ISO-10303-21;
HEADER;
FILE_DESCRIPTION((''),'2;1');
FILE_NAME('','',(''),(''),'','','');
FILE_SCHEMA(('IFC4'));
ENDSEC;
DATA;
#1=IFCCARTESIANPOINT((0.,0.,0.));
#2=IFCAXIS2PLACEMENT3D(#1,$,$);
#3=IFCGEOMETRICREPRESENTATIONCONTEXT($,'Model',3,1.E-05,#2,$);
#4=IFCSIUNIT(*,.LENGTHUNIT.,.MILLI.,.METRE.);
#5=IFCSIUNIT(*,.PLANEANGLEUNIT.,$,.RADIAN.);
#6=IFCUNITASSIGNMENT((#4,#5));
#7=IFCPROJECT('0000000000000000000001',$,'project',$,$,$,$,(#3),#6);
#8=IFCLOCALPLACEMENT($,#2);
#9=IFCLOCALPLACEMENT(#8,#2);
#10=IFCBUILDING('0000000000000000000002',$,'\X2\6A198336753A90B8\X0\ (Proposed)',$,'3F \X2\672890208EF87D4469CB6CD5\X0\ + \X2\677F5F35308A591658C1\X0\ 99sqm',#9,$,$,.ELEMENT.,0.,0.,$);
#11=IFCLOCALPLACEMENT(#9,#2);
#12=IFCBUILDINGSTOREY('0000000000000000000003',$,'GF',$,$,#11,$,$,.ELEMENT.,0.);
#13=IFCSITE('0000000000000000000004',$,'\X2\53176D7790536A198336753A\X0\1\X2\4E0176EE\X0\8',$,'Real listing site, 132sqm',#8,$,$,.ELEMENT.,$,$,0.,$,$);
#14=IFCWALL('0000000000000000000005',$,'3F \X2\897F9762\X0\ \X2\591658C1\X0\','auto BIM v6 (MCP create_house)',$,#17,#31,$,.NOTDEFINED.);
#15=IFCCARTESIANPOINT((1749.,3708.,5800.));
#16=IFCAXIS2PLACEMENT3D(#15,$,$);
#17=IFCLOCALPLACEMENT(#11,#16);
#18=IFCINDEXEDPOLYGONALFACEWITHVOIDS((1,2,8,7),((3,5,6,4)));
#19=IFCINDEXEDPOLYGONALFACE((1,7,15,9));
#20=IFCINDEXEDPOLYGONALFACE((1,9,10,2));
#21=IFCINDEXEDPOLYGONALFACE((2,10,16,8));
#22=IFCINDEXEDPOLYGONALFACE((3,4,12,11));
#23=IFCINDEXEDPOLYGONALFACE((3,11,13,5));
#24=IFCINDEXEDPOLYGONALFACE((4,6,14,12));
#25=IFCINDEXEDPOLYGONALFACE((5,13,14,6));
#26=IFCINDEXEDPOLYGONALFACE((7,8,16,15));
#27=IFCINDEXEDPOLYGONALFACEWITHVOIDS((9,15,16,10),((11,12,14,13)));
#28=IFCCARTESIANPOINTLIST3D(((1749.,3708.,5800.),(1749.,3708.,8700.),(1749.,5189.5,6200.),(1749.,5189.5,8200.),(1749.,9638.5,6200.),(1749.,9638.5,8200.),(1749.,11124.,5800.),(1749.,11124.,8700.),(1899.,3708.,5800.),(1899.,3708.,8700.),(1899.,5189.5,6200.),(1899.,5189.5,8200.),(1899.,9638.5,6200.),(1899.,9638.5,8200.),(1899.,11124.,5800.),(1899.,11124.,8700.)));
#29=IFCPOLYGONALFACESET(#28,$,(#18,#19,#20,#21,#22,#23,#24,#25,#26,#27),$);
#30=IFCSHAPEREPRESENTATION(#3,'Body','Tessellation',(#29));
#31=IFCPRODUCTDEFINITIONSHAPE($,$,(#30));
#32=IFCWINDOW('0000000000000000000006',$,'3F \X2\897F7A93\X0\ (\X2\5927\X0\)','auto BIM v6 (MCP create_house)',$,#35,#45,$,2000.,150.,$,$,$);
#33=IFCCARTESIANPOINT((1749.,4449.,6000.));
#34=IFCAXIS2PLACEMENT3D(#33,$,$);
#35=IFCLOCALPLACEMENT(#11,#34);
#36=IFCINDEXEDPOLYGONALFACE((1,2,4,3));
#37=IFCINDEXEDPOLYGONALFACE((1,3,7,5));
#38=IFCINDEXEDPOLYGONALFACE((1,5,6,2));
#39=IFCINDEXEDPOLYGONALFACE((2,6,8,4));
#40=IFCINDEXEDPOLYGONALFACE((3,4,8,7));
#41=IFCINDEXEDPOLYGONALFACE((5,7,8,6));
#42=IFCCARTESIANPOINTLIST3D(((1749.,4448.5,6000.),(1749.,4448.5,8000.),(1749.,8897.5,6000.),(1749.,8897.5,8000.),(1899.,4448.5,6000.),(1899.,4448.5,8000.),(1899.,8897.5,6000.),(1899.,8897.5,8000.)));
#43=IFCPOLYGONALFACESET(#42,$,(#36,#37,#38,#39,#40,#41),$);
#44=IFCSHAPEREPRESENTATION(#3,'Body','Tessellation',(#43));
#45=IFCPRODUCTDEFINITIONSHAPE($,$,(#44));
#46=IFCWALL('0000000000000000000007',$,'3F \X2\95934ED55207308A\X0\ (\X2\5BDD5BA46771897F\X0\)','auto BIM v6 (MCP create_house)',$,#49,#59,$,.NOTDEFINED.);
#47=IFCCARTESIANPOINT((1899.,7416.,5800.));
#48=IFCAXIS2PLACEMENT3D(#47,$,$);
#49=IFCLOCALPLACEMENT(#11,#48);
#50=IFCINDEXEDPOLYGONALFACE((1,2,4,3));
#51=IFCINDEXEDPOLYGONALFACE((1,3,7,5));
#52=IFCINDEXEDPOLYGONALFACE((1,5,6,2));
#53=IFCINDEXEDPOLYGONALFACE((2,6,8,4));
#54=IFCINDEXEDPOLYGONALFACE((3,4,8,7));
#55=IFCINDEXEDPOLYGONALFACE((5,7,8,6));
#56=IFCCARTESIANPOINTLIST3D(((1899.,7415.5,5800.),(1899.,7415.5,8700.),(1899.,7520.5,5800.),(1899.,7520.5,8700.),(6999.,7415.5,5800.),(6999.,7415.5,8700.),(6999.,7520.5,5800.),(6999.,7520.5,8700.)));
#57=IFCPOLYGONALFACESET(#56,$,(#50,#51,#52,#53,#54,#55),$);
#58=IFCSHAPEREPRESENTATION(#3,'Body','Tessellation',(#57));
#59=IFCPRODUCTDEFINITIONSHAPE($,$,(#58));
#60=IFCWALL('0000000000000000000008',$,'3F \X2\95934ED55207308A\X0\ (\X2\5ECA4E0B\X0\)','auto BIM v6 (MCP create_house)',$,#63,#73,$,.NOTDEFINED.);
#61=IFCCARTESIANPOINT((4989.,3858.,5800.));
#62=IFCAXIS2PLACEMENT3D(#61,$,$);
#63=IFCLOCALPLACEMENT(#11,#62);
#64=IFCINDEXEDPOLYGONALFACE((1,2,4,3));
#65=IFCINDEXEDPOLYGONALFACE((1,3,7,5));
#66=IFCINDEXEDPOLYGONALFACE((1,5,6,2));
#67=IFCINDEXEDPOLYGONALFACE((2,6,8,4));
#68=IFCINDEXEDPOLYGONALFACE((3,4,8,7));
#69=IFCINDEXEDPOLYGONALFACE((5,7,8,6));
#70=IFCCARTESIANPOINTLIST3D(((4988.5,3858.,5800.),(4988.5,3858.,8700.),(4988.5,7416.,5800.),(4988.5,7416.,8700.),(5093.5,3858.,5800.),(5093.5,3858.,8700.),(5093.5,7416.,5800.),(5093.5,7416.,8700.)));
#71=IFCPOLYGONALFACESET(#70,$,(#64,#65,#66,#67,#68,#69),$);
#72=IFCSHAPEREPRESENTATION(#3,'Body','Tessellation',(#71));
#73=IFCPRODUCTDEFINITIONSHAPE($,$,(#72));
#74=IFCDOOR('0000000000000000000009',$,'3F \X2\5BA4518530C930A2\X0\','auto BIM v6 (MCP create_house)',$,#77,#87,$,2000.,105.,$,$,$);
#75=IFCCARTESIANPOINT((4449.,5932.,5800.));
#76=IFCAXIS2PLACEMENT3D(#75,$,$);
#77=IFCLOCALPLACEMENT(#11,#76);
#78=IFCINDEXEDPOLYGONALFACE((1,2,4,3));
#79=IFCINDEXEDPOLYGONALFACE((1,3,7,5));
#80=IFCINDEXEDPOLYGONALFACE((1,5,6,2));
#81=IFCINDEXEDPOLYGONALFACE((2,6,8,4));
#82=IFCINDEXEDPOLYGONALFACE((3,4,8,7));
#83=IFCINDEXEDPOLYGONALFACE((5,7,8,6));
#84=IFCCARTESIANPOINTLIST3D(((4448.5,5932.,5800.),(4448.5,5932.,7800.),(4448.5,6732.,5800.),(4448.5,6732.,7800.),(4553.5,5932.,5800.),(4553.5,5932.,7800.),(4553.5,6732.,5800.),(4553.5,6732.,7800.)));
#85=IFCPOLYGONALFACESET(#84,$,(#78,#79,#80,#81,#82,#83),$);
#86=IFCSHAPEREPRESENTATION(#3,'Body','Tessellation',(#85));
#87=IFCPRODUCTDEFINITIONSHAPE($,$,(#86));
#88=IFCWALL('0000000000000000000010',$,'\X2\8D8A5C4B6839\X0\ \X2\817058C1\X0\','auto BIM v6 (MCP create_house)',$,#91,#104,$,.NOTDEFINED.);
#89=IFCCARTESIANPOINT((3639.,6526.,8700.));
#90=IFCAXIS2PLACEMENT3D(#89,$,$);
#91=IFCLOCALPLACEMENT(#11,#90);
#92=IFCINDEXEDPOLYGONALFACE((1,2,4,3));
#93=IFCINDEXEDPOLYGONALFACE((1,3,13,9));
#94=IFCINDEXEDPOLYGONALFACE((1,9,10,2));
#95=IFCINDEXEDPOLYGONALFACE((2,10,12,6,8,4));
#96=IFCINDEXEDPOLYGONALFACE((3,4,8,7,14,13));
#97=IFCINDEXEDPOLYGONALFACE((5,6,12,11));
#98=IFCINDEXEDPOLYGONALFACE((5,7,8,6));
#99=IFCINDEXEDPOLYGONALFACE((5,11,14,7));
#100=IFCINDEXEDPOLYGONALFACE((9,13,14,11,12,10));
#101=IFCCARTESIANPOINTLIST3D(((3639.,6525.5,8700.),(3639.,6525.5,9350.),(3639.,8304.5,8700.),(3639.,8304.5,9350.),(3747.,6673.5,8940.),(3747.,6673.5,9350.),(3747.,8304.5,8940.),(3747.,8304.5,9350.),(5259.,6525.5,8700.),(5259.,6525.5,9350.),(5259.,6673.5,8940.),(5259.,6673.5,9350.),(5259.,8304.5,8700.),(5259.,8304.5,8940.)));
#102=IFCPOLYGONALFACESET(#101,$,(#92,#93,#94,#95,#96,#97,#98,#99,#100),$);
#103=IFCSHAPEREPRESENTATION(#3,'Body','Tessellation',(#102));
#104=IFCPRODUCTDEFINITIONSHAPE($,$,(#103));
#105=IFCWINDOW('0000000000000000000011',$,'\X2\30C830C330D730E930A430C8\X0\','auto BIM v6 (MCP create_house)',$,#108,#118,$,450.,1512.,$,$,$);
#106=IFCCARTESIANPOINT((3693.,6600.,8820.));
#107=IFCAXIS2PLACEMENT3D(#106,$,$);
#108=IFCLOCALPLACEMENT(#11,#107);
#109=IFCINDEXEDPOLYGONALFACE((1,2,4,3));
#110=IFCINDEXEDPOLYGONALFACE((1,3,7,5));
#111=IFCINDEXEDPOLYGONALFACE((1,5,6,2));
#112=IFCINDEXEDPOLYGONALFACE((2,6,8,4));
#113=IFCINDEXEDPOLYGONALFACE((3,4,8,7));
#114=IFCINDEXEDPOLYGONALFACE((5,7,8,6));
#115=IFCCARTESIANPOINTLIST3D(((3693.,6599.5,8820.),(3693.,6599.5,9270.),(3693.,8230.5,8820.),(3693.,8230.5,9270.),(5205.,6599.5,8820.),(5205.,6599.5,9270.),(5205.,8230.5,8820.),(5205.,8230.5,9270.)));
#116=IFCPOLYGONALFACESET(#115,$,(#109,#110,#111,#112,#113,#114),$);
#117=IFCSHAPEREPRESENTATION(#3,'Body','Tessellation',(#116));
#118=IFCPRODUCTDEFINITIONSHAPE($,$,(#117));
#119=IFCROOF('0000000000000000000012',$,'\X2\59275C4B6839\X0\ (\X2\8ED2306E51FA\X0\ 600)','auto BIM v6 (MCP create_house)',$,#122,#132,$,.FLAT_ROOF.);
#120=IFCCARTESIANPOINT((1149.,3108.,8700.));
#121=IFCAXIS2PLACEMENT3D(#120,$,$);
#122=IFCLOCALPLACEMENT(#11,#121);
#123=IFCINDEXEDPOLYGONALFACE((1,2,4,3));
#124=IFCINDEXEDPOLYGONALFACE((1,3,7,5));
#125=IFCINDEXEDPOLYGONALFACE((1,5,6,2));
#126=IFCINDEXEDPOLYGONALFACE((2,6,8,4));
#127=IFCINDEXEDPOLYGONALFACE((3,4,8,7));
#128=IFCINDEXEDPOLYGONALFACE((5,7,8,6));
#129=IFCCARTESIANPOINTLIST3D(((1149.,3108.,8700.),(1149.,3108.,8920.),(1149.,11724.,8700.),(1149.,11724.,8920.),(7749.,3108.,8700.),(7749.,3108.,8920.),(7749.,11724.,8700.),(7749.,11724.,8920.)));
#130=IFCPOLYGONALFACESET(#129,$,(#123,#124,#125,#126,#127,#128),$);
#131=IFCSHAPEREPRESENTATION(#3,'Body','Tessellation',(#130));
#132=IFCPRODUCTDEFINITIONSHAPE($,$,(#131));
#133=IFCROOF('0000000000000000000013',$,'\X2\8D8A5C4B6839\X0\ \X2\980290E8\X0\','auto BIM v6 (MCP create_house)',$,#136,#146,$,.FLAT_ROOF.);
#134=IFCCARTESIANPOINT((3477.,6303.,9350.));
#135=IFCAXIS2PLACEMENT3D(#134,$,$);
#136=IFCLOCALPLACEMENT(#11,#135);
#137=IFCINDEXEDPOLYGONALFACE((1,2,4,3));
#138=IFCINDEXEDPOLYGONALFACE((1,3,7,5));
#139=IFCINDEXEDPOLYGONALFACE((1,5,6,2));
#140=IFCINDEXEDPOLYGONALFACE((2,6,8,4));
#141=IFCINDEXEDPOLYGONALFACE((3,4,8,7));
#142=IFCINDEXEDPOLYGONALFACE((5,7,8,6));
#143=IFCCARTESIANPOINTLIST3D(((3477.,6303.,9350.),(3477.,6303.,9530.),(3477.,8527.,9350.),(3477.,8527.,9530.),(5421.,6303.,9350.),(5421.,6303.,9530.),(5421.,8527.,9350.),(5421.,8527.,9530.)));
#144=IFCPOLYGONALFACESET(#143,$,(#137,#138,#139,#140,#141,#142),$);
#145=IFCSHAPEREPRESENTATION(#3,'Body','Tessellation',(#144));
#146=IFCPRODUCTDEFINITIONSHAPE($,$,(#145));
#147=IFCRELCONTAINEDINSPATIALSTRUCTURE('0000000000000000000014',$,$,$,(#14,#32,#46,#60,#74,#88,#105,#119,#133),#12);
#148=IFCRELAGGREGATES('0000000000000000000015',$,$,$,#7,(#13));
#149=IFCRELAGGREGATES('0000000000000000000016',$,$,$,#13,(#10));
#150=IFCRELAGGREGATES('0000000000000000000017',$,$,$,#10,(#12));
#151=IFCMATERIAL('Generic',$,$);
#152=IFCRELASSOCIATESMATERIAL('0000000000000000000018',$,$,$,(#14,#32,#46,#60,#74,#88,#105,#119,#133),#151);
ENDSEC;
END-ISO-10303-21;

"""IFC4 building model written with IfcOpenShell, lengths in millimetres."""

from ifc_helpers import new_model, si_unit, frame, frame_2d, origin, place, context, project, spatial, rectangle, extrude, material, element, fill, save


model = new_model("IFC4")

# Units and contexts
model_context = context("Model", 3, precision=1e-05, world=origin())
ifc_project = project(units=[si_unit("LENGTHUNIT", "METRE", prefix="MILLI"), si_unit("PLANEANGLEUNIT", "RADIAN")], contexts=[model_context])

# Site, building, storey
site_placement = place(None, origin())
site = spatial("IfcSite", under=ifc_project, at=site_placement, Name="北海道標茶町1丁目8", ObjectType="Real listing site, 132sqm", CompositionType="ELEMENT", RefElevation=0.0)
building_placement = place(site_placement, origin())
building = spatial("IfcBuilding", under=site, at=building_placement, Name="標茶町邸 (Proposed)", ObjectType="3F 木造軸組構法 + 板張り外壁 99sqm", CompositionType="ELEMENT", ElevationOfRefHeight=0.0, ElevationOfTerrain=0.0)
storey_placement = place(building_placement, origin())
storey = spatial("IfcBuildingStorey", under=building, at=storey_placement, Name="GF", CompositionType="ELEMENT", Elevation=0.0)

# Shared definitions
ifc_material = material(Name="Generic")

# Wall, opening, window
wall_1_placement = place(storey_placement, frame((1749.0, 3708.0, 5800.0)))
wall_1 = element("IfcWall", 1, at=wall_1_placement, inside=storey, material=ifc_material, Name="3F 西面 外壁", Description="auto BIM v6 (MCP create_house)", PredefinedType="NOTDEFINED", context=model_context, shape_type="SweptSolid", body=[
    extrude(rectangle(XDim=150.0, YDim=7416.0, at=frame_2d((75.0, 3708.0))), frame((1749.0, 3708.0, 5800.0)), (0.0, 0.0, 1.0), 2900.0),
])
opening_1_placement = place(storey_placement, frame((1749.0, 4449.0, 6000.0)))
opening_1 = element("IfcOpeningElement", 2, at=opening_1_placement, cuts=wall_1, PredefinedType="NOTDEFINED", context=model_context, shape_type="SweptSolid", body=[
    extrude(rectangle(XDim=150.0, YDim=4449.0, at=frame_2d((75.0, 2224.0))), frame((1749.0, 4449.0, 6000.0)), (0.0, 0.0, 1.0), 2000.0),
])
window_1_placement = place(storey_placement, frame((1749.0, 4449.0, 6000.0)))
window_1 = element("IfcWindow", 3, at=window_1_placement, inside=storey, material=ifc_material, Name="3F 西窓 (大)", Description="auto BIM v6 (MCP create_house)", OverallHeight=2000.0, OverallWidth=150.0, context=model_context, shape_type="SweptSolid", body=[
    extrude(rectangle(XDim=150.0, YDim=4449.0, at=frame_2d((75.0, 2224.0))), frame((1749.0, 4449.0, 6000.0)), (0.0, 0.0, 1.0), 2000.0),
])
fill(opening_1, window_1)

# Walls
wall_2_placement = place(storey_placement, frame((1899.0, 7416.0, 5800.0)))
element("IfcWall", 4, at=wall_2_placement, inside=storey, material=ifc_material, Name="3F 間仕切り (寝室東西)", Description="auto BIM v6 (MCP create_house)", PredefinedType="NOTDEFINED", context=model_context, shape_type="SweptSolid", body=[
    extrude(rectangle(XDim=5100.0, YDim=105.0, at=frame_2d((2550.0, 52.0))), frame((1899.0, 7416.0, 5800.0)), (0.0, 0.0, 1.0), 2900.0),
])
wall_3_placement = place(storey_placement, frame((4989.0, 3858.0, 5800.0)))
element("IfcWall", 5, at=wall_3_placement, inside=storey, material=ifc_material, Name="3F 間仕切り (廊下)", Description="auto BIM v6 (MCP create_house)", PredefinedType="NOTDEFINED", context=model_context, shape_type="SweptSolid", body=[
    extrude(rectangle(XDim=105.0, YDim=3558.0, at=frame_2d((52.0, 1779.0))), frame((4989.0, 3858.0, 5800.0)), (0.0, 0.0, 1.0), 2900.0),
])

# Door
door_1_placement = place(storey_placement, frame((4449.0, 5932.0, 5800.0)))
element("IfcDoor", 6, at=door_1_placement, inside=storey, material=ifc_material, Name="3F 室内ドア", Description="auto BIM v6 (MCP create_house)", OverallHeight=2000.0, OverallWidth=105.0, context=model_context, shape_type="SweptSolid", body=[
    extrude(rectangle(XDim=105.0, YDim=800.0, at=frame_2d((52.0, 400.0))), frame((4449.0, 5932.0, 5800.0)), (0.0, 0.0, 1.0), 2000.0),
])

# Wall, opening, window
wall_4_placement = place(storey_placement, frame((3639.0, 6526.0, 8700.0)))
wall_4 = element("IfcWall", 7, at=wall_4_placement, inside=storey, material=ifc_material, Name="越屋根 腰壁", Description="auto BIM v6 (MCP create_house)", PredefinedType="NOTDEFINED", context=model_context, shape_type="SweptSolid", body=[
    extrude(rectangle(XDim=1620.0, YDim=1779.0, at=frame_2d((810.0, 889.0))), frame((3639.0, 6526.0, 8700.0)), (0.0, 0.0, 1.0), 650.0),
])
opening_2_placement = place(storey_placement, frame((3693.0, 6600.0, 8820.0)))
opening_2 = element("IfcOpeningElement", 8, at=opening_2_placement, cuts=wall_4, PredefinedType="NOTDEFINED", context=model_context, shape_type="SweptSolid", body=[
    extrude(rectangle(XDim=1512.0, YDim=1631.0, at=frame_2d((756.0, 815.0))), frame((3693.0, 6600.0, 8820.0)), (0.0, 0.0, 1.0), 450.0),
])
window_2_placement = place(storey_placement, frame((3693.0, 6600.0, 8820.0)))
window_2 = element("IfcWindow", 9, at=window_2_placement, inside=storey, material=ifc_material, Name="トップライト", Description="auto BIM v6 (MCP create_house)", OverallHeight=450.0, OverallWidth=1512.0, context=model_context, shape_type="SweptSolid", body=[
    extrude(rectangle(XDim=1512.0, YDim=1631.0, at=frame_2d((756.0, 815.0))), frame((3693.0, 6600.0, 8820.0)), (0.0, 0.0, 1.0), 450.0),
])
fill(opening_2, window_2)

# Roofs
roof_1_placement = place(storey_placement, frame((1149.0, 3108.0, 8700.0)))
element("IfcRoof", 10, at=roof_1_placement, inside=storey, material=ifc_material, Name="大屋根 (軒の出 600)", Description="auto BIM v6 (MCP create_house)", PredefinedType="FLAT_ROOF", context=model_context, shape_type="SweptSolid", body=[
    extrude(rectangle(XDim=6600.0, YDim=8616.0, at=frame_2d((3300.0, 4308.0))), frame((1149.0, 3108.0, 8700.0)), (0.0, 0.0, 1.0), 220.0),
])
roof_2_placement = place(storey_placement, frame((3477.0, 6303.0, 9350.0)))
element("IfcRoof", 11, at=roof_2_placement, inside=storey, material=ifc_material, Name="越屋根 頂部", Description="auto BIM v6 (MCP create_house)", PredefinedType="FLAT_ROOF", context=model_context, shape_type="SweptSolid", body=[
    extrude(rectangle(XDim=1944.0, YDim=2224.0, at=frame_2d((972.0, 1112.0))), frame((3477.0, 6303.0, 9350.0)), (0.0, 0.0, 1.0), 180.0),
])

save(model, "model.ifc")
